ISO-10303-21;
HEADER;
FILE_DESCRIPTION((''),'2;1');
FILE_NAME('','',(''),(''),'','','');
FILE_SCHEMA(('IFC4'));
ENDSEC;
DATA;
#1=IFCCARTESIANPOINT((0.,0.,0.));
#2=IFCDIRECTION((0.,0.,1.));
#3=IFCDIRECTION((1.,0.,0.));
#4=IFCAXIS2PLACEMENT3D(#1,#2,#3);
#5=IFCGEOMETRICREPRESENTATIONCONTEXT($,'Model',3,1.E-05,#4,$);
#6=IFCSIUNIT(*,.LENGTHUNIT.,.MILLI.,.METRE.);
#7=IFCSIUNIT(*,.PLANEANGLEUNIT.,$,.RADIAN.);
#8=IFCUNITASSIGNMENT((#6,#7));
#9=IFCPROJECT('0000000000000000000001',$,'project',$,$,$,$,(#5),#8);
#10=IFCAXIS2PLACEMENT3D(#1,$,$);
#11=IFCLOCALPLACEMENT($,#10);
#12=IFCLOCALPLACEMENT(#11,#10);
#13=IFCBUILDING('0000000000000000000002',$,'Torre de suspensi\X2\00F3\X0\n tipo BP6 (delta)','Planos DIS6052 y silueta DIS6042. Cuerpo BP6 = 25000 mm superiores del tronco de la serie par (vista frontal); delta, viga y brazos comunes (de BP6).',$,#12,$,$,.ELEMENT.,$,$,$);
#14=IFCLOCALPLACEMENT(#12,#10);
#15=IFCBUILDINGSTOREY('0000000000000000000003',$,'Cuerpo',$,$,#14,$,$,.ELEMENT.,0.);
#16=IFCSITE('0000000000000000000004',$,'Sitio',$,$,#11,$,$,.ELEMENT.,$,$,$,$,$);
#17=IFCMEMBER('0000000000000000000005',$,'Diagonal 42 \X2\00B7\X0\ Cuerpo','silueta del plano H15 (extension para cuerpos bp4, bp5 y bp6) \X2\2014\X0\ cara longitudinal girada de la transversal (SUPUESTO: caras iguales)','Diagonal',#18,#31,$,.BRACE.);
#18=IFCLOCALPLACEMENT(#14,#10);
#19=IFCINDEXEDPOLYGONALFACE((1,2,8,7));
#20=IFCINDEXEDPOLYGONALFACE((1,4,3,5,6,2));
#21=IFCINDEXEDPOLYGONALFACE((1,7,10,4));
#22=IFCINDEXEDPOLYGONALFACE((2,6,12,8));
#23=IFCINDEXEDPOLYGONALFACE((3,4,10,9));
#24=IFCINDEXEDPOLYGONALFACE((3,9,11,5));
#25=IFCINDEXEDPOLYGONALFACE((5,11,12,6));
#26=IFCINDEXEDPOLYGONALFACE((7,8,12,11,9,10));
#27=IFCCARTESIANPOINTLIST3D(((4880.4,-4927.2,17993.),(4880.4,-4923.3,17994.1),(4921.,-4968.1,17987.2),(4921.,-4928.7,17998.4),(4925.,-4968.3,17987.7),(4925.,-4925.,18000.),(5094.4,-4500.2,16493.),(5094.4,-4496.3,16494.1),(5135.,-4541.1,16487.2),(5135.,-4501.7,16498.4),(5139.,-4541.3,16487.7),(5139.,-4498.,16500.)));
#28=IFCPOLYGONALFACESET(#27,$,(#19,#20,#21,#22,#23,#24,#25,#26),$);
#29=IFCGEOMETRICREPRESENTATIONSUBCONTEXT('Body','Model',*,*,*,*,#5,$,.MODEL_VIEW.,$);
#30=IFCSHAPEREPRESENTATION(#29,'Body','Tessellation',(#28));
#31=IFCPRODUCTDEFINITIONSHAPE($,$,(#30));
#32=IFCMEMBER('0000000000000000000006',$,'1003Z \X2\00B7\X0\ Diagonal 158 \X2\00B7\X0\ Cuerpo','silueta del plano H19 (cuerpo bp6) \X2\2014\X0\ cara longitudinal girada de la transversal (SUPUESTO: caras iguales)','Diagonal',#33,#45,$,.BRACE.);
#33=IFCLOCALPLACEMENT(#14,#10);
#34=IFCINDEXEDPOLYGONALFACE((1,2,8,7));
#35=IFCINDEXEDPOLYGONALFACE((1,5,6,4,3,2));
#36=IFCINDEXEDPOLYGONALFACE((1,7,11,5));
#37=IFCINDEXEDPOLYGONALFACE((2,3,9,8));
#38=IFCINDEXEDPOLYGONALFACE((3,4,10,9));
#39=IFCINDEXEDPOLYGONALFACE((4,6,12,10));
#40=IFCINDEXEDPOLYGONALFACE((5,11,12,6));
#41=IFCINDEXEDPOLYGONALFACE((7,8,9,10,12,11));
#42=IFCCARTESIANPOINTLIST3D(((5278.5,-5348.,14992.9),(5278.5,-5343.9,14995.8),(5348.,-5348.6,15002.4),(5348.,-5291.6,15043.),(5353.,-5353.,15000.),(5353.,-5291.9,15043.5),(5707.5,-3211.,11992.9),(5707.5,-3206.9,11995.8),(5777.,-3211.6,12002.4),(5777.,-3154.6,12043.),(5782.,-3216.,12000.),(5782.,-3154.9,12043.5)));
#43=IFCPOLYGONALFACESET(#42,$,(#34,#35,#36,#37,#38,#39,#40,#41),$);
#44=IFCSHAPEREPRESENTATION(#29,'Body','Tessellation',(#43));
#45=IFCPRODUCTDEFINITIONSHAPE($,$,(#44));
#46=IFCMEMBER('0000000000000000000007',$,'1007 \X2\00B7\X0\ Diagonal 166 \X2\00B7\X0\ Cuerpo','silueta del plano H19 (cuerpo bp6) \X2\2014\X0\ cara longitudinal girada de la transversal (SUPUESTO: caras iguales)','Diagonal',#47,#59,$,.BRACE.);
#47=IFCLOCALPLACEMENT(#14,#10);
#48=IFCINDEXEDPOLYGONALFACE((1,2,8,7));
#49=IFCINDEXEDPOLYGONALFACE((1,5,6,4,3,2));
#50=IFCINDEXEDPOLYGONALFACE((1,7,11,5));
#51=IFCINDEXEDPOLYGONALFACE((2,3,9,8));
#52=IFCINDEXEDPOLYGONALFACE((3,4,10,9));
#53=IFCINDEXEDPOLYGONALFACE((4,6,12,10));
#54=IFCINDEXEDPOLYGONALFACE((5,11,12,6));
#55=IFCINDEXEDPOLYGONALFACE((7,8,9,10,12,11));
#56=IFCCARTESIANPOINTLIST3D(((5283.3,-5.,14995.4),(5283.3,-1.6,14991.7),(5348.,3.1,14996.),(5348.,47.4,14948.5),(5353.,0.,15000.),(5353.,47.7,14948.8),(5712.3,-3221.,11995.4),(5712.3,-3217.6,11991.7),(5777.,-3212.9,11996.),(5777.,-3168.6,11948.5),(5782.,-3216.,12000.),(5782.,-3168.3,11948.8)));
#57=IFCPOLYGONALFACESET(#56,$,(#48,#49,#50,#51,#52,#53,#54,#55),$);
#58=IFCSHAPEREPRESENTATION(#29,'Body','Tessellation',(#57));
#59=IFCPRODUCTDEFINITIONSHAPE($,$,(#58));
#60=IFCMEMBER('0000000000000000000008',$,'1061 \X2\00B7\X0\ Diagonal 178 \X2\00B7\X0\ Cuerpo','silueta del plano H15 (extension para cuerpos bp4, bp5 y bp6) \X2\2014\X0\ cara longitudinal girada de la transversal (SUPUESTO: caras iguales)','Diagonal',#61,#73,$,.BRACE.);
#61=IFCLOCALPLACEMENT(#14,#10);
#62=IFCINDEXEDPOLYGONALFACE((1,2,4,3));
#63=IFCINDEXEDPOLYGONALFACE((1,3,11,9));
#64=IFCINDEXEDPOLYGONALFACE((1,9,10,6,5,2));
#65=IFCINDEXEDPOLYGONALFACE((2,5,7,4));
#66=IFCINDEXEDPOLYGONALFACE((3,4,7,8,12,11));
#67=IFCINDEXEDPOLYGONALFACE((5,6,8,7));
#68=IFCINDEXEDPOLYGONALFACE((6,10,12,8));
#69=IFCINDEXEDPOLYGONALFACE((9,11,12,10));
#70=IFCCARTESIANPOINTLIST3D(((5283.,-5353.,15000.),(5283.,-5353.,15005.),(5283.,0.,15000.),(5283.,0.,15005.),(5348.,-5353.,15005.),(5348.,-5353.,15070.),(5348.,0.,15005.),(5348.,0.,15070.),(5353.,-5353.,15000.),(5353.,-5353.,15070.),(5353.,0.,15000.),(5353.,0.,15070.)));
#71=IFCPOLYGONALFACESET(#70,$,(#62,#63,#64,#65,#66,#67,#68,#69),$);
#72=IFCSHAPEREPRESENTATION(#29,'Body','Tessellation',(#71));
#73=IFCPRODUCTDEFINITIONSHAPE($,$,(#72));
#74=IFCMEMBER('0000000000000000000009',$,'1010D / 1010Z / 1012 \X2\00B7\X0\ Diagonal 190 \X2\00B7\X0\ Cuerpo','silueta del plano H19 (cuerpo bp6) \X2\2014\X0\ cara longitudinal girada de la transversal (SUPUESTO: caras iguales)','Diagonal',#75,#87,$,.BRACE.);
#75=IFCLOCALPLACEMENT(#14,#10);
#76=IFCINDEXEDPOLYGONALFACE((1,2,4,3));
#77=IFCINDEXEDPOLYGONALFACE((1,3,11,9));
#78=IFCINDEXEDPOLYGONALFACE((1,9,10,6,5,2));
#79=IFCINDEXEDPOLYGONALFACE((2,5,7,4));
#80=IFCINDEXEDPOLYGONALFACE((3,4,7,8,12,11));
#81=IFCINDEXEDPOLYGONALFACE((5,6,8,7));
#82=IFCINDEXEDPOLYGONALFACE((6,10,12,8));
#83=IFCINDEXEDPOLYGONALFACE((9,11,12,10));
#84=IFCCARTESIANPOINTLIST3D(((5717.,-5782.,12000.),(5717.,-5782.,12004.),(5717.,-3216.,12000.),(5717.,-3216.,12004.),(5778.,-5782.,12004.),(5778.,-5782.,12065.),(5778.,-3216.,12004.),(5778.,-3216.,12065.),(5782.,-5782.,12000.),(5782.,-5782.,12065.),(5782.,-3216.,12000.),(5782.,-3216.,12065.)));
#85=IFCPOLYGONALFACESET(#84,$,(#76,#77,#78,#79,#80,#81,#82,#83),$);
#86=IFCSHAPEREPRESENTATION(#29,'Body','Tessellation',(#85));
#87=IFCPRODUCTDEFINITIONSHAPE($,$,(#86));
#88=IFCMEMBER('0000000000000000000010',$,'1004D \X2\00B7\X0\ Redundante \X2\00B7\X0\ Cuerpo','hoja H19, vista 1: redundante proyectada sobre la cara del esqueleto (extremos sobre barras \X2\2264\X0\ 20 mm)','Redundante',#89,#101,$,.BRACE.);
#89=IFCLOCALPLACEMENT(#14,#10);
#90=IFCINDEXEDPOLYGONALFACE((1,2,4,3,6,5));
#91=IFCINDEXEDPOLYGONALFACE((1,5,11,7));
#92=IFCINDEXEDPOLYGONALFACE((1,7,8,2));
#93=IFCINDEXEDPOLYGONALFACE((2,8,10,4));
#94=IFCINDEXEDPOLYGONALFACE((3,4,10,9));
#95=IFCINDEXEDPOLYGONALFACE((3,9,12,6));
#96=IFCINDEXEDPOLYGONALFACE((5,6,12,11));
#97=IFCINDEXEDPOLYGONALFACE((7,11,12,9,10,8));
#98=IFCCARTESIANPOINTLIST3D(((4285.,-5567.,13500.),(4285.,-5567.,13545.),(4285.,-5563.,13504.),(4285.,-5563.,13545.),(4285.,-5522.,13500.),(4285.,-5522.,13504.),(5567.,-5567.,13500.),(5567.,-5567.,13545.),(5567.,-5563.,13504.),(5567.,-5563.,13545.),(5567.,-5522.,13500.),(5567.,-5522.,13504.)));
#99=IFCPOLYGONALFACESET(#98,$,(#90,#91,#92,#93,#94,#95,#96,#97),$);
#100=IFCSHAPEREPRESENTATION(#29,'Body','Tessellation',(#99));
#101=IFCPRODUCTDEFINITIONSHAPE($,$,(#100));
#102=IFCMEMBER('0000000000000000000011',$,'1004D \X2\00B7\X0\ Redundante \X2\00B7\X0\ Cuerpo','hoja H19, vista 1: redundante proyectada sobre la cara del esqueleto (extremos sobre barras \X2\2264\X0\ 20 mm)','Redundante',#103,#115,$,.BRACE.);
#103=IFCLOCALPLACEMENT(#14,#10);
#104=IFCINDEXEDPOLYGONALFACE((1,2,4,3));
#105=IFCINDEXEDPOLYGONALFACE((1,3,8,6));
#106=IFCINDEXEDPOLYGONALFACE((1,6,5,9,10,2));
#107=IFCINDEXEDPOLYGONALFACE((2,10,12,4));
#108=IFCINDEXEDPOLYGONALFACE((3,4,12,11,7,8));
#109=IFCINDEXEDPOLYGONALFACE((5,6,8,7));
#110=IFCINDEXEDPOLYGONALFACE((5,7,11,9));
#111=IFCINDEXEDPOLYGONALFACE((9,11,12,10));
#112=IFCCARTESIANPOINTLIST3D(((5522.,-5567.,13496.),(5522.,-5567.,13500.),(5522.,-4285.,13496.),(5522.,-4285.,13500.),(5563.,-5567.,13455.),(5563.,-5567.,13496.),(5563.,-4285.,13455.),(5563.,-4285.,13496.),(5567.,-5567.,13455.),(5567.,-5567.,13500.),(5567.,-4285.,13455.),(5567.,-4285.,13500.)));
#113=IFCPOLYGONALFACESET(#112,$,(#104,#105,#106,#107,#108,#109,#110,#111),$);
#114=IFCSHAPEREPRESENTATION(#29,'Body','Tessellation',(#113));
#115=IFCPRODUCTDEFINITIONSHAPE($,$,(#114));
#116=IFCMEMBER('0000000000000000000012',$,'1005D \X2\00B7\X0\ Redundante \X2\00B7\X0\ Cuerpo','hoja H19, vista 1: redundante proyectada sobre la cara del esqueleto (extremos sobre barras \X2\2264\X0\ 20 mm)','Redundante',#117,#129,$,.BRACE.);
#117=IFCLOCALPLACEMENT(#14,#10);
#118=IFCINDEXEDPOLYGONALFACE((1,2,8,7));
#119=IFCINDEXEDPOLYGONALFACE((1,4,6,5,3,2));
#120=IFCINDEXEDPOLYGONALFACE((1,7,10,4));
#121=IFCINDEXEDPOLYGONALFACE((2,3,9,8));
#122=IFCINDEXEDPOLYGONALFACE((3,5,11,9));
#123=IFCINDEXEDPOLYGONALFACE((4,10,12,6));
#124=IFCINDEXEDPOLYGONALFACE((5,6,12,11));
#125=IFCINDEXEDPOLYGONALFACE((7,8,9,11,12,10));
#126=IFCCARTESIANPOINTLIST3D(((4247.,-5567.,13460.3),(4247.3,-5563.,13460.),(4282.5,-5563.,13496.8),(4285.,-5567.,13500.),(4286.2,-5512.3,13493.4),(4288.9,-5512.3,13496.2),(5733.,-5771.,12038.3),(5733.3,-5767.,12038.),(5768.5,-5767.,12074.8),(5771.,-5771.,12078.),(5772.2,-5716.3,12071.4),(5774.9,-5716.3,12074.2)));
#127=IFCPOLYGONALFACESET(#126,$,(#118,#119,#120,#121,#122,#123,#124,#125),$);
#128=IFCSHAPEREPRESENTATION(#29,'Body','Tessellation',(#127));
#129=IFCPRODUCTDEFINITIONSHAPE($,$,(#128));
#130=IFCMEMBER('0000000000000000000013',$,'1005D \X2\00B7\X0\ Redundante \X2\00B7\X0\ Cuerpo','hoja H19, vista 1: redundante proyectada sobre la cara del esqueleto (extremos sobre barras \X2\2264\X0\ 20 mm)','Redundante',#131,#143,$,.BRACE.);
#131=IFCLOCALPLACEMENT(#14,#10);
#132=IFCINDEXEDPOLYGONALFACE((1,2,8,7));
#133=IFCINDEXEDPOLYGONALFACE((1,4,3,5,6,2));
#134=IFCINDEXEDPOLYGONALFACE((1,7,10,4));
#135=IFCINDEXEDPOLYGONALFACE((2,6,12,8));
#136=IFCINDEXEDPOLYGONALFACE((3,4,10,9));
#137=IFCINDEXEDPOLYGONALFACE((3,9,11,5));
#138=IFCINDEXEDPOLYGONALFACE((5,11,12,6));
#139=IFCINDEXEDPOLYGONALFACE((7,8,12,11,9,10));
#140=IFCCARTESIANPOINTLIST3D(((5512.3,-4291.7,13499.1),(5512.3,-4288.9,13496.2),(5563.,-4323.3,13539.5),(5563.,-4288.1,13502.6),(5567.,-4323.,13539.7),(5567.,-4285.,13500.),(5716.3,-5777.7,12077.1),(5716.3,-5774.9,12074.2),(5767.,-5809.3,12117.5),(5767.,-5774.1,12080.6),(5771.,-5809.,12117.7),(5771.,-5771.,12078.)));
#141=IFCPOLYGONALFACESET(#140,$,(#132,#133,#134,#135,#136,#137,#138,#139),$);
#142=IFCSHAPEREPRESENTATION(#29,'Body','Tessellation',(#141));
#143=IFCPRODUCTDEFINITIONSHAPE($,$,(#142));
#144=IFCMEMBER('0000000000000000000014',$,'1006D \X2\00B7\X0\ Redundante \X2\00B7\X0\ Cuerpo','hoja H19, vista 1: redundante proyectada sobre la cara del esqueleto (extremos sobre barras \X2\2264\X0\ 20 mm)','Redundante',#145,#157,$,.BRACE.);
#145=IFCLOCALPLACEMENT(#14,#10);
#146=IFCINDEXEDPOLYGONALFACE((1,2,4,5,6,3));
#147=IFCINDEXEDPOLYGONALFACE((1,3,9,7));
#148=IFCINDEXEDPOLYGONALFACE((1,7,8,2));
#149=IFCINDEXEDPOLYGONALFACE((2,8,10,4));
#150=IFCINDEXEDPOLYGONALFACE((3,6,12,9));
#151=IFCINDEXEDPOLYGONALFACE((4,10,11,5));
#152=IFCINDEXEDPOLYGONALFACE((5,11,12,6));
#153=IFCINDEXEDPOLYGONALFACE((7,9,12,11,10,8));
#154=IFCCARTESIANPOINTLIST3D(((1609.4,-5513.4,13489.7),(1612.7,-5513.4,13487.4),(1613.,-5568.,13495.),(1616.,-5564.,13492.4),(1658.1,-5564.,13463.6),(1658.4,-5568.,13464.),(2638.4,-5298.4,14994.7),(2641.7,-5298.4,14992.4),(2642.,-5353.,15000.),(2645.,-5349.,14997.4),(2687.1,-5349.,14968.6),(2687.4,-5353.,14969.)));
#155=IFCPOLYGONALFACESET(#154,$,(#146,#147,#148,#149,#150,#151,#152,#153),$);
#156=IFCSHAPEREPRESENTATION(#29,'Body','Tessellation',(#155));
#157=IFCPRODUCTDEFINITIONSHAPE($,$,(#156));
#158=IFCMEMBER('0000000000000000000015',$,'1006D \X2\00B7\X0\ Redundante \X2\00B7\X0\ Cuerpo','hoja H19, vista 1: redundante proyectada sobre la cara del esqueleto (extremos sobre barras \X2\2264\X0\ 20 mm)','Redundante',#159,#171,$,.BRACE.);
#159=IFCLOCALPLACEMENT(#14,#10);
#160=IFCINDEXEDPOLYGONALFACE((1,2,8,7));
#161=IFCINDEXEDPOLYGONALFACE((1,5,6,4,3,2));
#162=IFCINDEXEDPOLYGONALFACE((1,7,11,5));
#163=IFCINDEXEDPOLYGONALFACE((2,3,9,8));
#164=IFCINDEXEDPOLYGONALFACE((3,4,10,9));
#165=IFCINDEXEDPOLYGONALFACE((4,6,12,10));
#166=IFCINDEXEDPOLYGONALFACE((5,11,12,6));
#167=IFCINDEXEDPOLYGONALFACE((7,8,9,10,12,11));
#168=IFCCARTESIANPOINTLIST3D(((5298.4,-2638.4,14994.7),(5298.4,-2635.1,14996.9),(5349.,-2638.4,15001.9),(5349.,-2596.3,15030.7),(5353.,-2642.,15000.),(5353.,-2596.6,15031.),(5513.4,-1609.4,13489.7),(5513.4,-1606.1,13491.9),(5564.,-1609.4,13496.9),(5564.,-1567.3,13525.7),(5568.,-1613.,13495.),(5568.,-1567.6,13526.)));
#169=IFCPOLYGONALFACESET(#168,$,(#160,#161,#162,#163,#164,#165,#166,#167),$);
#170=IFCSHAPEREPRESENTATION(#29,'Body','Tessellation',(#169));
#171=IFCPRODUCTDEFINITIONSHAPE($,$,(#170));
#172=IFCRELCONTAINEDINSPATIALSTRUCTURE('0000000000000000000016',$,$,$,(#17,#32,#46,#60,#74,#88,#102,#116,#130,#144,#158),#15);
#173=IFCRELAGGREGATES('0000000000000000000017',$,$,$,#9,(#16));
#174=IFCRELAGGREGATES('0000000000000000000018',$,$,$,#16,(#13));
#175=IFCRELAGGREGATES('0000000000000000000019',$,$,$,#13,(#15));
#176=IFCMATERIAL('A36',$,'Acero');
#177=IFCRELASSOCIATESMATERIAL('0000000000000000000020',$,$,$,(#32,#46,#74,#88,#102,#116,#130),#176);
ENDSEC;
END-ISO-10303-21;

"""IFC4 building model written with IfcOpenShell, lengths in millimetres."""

from ifc_helpers import new_model, si_unit, frame, frame_2d, origin, origin_with_axes, place, context, subcontext, project, spatial, l_section, extrude, material, element, save


model = new_model("IFC4")

# Units and contexts
model_context = context("Model", 3, precision=1e-05, world=origin_with_axes())
body_context = subcontext(model_context, "Body", "Model", "MODEL_VIEW")
ifc_project = project(units=[si_unit("LENGTHUNIT", "METRE", prefix="MILLI"), si_unit("PLANEANGLEUNIT", "RADIAN")], contexts=[model_context])

# Site, building, storey
site_placement = place(None, origin())
site = spatial("IfcSite", under=ifc_project, at=site_placement, Name="Sitio", CompositionType="ELEMENT")
building_placement = place(site_placement, origin())
building = spatial("IfcBuilding", under=site, at=building_placement, Name="Torre de suspensión tipo BP6 (delta)", Description="Planos DIS6052 y silueta DIS6042. Cuerpo BP6 = 25000 mm superiores del tronco de la serie par (vista frontal); delta, viga y brazos comunes (de BP6).", CompositionType="ELEMENT")
storey_placement = place(building_placement, origin())
storey = spatial("IfcBuildingStorey", under=building, at=storey_placement, Name="Cuerpo", CompositionType="ELEMENT", Elevation=0.0)

# Members
ifc_material_1 = material(Name="A36", Category="Acero")
member_1_placement = place(storey_placement, frame((5139.0, -4498.0, 16500.0), z_axis=(-0.135942, -0.271248, 0.952861), x_axis=(-0.990717, 0.037219, -0.130747)))
element("IfcMember", 1, at=member_1_placement, inside=storey, Name="Diagonal 42 · Cuerpo", Description="silueta del plano H15 (extension para cuerpos bp4, bp5 y bp6) — cara longitudinal girada de la transversal (SUPUESTO: caras iguales)", ObjectType="Diagonal", PredefinedType="BRACE", context=body_context, shape_type="SweptSolid", body=[
    extrude(l_section(Depth=45.0, Width=45.0, Thickness=4.0, at=frame_2d((22.5, 22.5))), None, (0.0, 0.0, 1.0), 1574.2),
])
member_2_placement = place(storey_placement, frame((5353.0, -5353.0, 15000.0), z_axis=(0.115689, 0.576289, -0.809016), x_axis=(-0.993285, 0.067121, -0.094227)))
element("IfcMember", 2, at=member_2_placement, inside=storey, material=ifc_material_1, Name="1003Z · Diagonal 158 · Cuerpo", Description="silueta del plano H19 (cuerpo bp6) — cara longitudinal girada de la transversal (SUPUESTO: caras iguales)", ObjectType="Diagonal", PredefinedType="BRACE", context=body_context, shape_type="SweptSolid", body=[
    extrude(l_section(Depth=75.0, Width=75.0, Thickness=5.0, at=frame_2d((37.5, 37.5))), None, (0.0, 0.0, 1.0), 3708.2),
])
member_3_placement = place(storey_placement, frame((5353.0, 0.0, 15000.0), z_axis=(0.097083, -0.727783, -0.678902), x_axis=(-0.995276, -0.070991, -0.066223)))
element("IfcMember", 3, at=member_3_placement, inside=storey, material=ifc_material_1, Name="1007 · Diagonal 166 · Cuerpo", Description="silueta del plano H19 (cuerpo bp6) — cara longitudinal girada de la transversal (SUPUESTO: caras iguales)", ObjectType="Diagonal", PredefinedType="BRACE", context=body_context, shape_type="SweptSolid", body=[
    extrude(l_section(Depth=70.0, Width=70.0, Thickness=5.0, at=frame_2d((35.0, 35.0))), None, (0.0, 0.0, 1.0), 4418.9),
])
member_4_placement = place(storey_placement, frame((5353.0, -5353.0, 15000.0), z_axis=(0.0, 1.0, 0.0), x_axis=(-1.0, 0.0, 0.0)))
element("IfcMember", 4, at=member_4_placement, inside=storey, Name="1061 · Diagonal 178 · Cuerpo", Description="silueta del plano H15 (extension para cuerpos bp4, bp5 y bp6) — cara longitudinal girada de la transversal (SUPUESTO: caras iguales)", ObjectType="Diagonal", PredefinedType="BRACE", context=body_context, shape_type="SweptSolid", body=[
    extrude(l_section(Depth=70.0, Width=70.0, Thickness=5.0, at=frame_2d((35.0, 35.0))), None, (0.0, 0.0, 1.0), 5353.0),
])
member_5_placement = place(storey_placement, frame((5782.0, -5782.0, 12000.0), z_axis=(0.0, 1.0, 0.0), x_axis=(-1.0, 0.0, 0.0)))
element("IfcMember", 5, at=member_5_placement, inside=storey, material=ifc_material_1, Name="1010D / 1010Z / 1012 · Diagonal 190 · Cuerpo", Description="silueta del plano H19 (cuerpo bp6) — cara longitudinal girada de la transversal (SUPUESTO: caras iguales)", ObjectType="Diagonal", PredefinedType="BRACE", context=body_context, shape_type="SweptSolid", body=[
    extrude(l_section(Depth=65.0, Width=65.0, Thickness=4.0, at=frame_2d((32.5, 32.5))), None, (0.0, 0.0, 1.0), 2566.0),
])
for number, where, z_axis, x_axis, name in (
    (6, (4285.0, -5567.0, 13500.0), (1.0, 0.0, 0.0), (0.0, 1.0, 0.0), "1004D · Redundante · Cuerpo"),
    (7, (5567.0, -4285.0, 13500.0), (0.0, -1.0, 0.0), (-1.0, 0.0, 0.0), "1004D · Redundante · Cuerpo"),
):
    element("IfcMember", number, at=place(storey_placement, frame(where, z_axis=z_axis, x_axis=x_axis)), inside=storey, material=ifc_material_1, Name=name, Description="hoja H19, vista 1: redundante proyectada sobre la cara del esqueleto (extremos sobre barras ≤ 20 mm)", ObjectType="Redundante", PredefinedType="BRACE", context=body_context, shape_type="SweptSolid", body=[
        extrude(l_section(Depth=45.0, Width=45.0, Thickness=4.0, at=frame_2d((22.5, 22.5))), None, (0.0, 0.0, 1.0), 1282.0),
    ])
for number, where, z_axis, x_axis, name in (
    (8, (5771.0, -5771.0, 12078.0), (-0.718966, 0.098701, 0.688001), (0.071311, 0.995117, -0.068239), "1005D · Redundante · Cuerpo"),
    (9, (5771.0, -5771.0, 12078.0), (-0.098701, 0.718966, 0.688001), (-0.995117, -0.071311, -0.068239), "1005D · Redundante · Cuerpo"),
):
    element("IfcMember", number, at=place(storey_placement, frame(where, z_axis=z_axis, x_axis=x_axis)), inside=storey, material=ifc_material_1, Name=name, Description="hoja H19, vista 1: redundante proyectada sobre la cara del esqueleto (extremos sobre barras ≤ 20 mm)", ObjectType="Redundante", PredefinedType="BRACE", context=body_context, shape_type="SweptSolid", body=[
        extrude(l_section(Depth=55.0, Width=55.0, Thickness=4.0, at=frame_2d((27.5, 27.5))), None, (0.0, 0.0, 1.0), 2066.9),
    ])
for number, where, z_axis, x_axis, name in (
    (10, (2642.0, -5353.0, 15000.0), (-0.560524, -0.117116, -0.819815), (-0.066101, 0.993118, -0.096679), "1006D · Redundante · Cuerpo"),
    (11, (5353.0, -2642.0, 15000.0), (0.117116, 0.560524, -0.819815), (-0.993118, 0.066101, -0.096679), "1006D · Redundante · Cuerpo"),
):
    element("IfcMember", number, at=place(storey_placement, frame(where, z_axis=z_axis, x_axis=x_axis)), inside=storey, Name=name, Description="hoja H19, vista 1: redundante proyectada sobre la cara del esqueleto (extremos sobre barras ≤ 20 mm)", ObjectType="Redundante", PredefinedType="BRACE", context=body_context, shape_type="SweptSolid", body=[
        extrude(l_section(Depth=55.0, Width=55.0, Thickness=4.0, at=frame_2d((27.5, 27.5))), None, (0.0, 0.0, 1.0), 1835.8),
    ])

save(model, "model.ifc")
